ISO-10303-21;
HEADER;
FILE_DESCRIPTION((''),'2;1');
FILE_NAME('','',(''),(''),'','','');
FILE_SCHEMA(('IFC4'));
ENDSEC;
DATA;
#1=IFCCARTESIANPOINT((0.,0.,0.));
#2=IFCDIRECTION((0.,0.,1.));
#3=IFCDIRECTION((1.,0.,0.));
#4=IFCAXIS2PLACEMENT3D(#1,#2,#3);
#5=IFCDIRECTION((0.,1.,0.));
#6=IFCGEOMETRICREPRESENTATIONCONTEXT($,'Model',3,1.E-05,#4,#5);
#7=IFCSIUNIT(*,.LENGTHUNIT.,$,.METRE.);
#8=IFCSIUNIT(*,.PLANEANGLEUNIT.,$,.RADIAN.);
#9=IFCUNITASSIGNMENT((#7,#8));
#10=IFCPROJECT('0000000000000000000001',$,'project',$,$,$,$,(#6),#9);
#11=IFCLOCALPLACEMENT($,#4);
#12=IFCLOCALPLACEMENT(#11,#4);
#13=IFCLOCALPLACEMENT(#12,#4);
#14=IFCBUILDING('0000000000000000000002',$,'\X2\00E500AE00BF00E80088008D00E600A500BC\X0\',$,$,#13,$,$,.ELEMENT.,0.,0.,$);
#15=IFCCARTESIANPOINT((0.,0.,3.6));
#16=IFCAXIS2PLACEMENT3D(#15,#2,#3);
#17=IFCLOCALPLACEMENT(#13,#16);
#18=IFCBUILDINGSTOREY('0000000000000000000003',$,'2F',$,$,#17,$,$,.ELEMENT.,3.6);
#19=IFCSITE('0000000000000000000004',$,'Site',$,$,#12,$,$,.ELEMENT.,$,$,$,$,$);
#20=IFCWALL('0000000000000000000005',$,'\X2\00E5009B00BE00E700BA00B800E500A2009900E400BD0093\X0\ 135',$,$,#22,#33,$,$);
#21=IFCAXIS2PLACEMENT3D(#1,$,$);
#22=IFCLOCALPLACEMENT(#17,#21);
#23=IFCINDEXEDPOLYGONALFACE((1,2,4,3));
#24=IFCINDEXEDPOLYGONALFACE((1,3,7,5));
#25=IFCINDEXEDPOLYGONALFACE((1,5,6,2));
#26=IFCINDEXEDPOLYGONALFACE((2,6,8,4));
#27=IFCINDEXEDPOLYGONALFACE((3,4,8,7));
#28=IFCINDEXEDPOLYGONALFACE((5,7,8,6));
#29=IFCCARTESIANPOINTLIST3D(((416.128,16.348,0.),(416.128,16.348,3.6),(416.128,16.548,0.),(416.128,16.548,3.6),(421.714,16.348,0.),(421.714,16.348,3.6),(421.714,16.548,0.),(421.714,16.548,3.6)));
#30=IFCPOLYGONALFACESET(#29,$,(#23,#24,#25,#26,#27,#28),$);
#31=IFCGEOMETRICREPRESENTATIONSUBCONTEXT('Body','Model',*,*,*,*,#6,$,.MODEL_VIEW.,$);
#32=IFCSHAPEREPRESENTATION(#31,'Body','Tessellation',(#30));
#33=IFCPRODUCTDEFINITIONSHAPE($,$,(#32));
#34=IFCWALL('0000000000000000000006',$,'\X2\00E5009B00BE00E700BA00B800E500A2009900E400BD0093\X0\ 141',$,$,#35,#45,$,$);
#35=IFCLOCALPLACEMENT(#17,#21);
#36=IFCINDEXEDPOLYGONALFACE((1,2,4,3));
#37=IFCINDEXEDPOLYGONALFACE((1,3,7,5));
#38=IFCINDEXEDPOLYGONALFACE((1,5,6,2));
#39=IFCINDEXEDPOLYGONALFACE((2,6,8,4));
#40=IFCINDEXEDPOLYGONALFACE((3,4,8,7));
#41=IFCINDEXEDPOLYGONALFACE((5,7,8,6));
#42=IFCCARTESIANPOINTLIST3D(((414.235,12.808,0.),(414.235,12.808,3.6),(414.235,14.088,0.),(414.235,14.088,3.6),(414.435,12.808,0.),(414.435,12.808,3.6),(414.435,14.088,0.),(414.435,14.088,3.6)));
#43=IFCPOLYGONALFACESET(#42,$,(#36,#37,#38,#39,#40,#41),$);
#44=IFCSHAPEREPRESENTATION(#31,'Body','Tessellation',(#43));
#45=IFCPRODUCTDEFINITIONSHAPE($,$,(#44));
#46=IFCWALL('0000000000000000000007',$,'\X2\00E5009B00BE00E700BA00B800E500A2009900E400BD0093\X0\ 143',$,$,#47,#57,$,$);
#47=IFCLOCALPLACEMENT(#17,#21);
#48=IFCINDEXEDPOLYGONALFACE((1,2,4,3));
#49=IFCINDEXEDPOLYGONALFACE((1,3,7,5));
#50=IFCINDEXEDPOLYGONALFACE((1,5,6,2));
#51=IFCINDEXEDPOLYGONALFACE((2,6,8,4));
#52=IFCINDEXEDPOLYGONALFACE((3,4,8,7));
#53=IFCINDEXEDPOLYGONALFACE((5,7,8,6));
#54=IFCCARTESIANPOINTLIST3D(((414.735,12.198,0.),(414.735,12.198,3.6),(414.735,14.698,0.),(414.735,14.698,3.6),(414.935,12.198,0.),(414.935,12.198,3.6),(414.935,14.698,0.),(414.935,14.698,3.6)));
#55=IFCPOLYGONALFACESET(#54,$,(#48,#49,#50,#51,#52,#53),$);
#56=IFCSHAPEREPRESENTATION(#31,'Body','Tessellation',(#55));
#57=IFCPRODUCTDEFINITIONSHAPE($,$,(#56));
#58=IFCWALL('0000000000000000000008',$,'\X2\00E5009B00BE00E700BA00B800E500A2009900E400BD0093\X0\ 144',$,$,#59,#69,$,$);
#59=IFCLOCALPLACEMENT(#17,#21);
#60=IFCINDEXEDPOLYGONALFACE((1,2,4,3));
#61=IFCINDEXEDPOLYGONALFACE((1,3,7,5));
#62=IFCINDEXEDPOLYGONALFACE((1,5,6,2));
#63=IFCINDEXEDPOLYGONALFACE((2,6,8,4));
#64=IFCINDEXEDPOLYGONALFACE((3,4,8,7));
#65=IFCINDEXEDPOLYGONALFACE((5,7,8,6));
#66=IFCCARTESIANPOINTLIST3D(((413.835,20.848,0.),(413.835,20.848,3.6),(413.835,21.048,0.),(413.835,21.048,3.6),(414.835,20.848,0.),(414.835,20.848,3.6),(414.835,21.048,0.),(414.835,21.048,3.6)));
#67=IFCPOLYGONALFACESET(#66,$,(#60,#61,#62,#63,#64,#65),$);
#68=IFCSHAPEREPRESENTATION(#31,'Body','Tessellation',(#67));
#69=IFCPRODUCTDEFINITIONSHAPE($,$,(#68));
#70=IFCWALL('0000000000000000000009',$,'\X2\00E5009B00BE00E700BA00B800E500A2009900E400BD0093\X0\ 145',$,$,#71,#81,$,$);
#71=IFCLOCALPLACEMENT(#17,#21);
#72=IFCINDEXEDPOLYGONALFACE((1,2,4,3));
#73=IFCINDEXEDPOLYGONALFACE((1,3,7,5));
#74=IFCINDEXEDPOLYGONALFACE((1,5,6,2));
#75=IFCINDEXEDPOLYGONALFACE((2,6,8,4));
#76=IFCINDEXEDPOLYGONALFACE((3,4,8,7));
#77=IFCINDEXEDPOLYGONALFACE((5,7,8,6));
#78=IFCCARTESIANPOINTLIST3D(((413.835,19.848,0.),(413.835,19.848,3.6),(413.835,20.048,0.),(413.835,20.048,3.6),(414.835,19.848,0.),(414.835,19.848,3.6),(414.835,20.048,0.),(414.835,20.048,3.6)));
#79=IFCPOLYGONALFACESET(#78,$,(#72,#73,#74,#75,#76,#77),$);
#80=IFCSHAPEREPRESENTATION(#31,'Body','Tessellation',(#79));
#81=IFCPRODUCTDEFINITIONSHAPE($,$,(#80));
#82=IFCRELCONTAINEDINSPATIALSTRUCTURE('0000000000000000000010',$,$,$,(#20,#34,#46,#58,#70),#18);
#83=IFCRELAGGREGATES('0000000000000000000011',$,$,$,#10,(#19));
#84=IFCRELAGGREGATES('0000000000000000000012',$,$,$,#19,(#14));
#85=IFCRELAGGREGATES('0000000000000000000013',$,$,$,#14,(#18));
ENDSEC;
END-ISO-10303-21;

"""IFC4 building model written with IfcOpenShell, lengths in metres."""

from ifc_helpers import new_model, si_unit, direction, frame, frame_2d, origin_with_axes, place, context, subcontext, project, spatial, rectangle, extrude, element, save


model = new_model("IFC4")

# Units and contexts
model_context = context("Model", 3, precision=1e-05, world=origin_with_axes(), true_north=direction((0.0, 1.0, 0.0)))
body_context = subcontext(model_context, "Body", "Model", "MODEL_VIEW")
ifc_project = project(units=[si_unit("LENGTHUNIT", "METRE"), si_unit("PLANEANGLEUNIT", "RADIAN")], contexts=[model_context])

# Site, building, storey
placement = place(None, origin_with_axes())
site_placement = place(placement, origin_with_axes())
site = spatial("IfcSite", under=ifc_project, at=site_placement, Name="Site", CompositionType="ELEMENT")
building_placement = place(site_placement, origin_with_axes())
building = spatial("IfcBuilding", under=site, at=building_placement, Name="å®¿è\u0088\u008dæ¥¼", CompositionType="ELEMENT", ElevationOfRefHeight=0.0, ElevationOfTerrain=0.0)
storey_placement = place(building_placement, frame((0.0, 0.0, 3.6), z_axis=(0.0, 0.0, 1.0), x_axis=(1.0, 0.0, 0.0)))
storey = spatial("IfcBuildingStorey", under=building, at=storey_placement, Name="2F", CompositionType="ELEMENT", Elevation=3.6)

# Walls
wall_1_placement = place(storey_placement, frame((418.921, 16.448, 0.0), z_axis=(0.0, 0.0, 1.0), x_axis=(-1.0, 0.0, 0.0)))
element("IfcWall", 1, at=wall_1_placement, inside=storey, Name="å\u009b¾çº¸å¢\u0099ä½\u0093 135", context=body_context, shape_type="SweptSolid", body=[
    extrude(rectangle(XDim=5.586, YDim=0.2, at=frame_2d((0.0, 0.0), x_axis=(1.0, 0.0, 0.0))), frame((0.0, 0.0, 0.0), z_axis=(0.0, 0.0, 1.0)), (0.0, 0.0, 1.0), 3.6),
])
wall_2_placement = place(storey_placement, frame((414.335, 13.448, 0.0), z_axis=(0.0, 0.0, 1.0), x_axis=(0.0, -1.0, 0.0)))
element("IfcWall", 2, at=wall_2_placement, inside=storey, Name="å\u009b¾çº¸å¢\u0099ä½\u0093 141", context=body_context, shape_type="SweptSolid", body=[
    extrude(rectangle(XDim=1.28, YDim=0.2, at=frame_2d((0.0, 0.0), x_axis=(1.0, 0.0, 0.0))), frame((0.0, 0.0, 0.0), z_axis=(0.0, 0.0, 1.0)), (0.0, 0.0, 1.0), 3.6),
])
wall_3_placement = place(storey_placement, frame((414.835, 13.448, 0.0), z_axis=(0.0, 0.0, 1.0), x_axis=(0.0, 1.0, 0.0)))
element("IfcWall", 3, at=wall_3_placement, inside=storey, Name="å\u009b¾çº¸å¢\u0099ä½\u0093 143", context=body_context, shape_type="SweptSolid", body=[
    extrude(rectangle(XDim=2.5, YDim=0.2, at=frame_2d((0.0, 0.0), x_axis=(1.0, 0.0, 0.0))), frame((0.0, 0.0, 0.0), z_axis=(0.0, 0.0, 1.0)), (0.0, 0.0, 1.0), 3.6),
])
for number, where, z_axis, x_axis, name in (
    (4, (414.335, 20.948, 0.0), (0.0, 0.0, 1.0), (-1.0, 0.0, 0.0), "å\u009b¾çº¸å¢\u0099ä½\u0093 144"),
    (5, (414.335, 19.948, 0.0), (0.0, 0.0, 1.0), (-1.0, 0.0, 0.0), "å\u009b¾çº¸å¢\u0099ä½\u0093 145"),
):
    element("IfcWall", number, at=place(storey_placement, frame(where, z_axis=z_axis, x_axis=x_axis)), inside=storey, Name=name, context=body_context, shape_type="SweptSolid", body=[
        extrude(rectangle(XDim=1.0, YDim=0.2, at=frame_2d((0.0, 0.0), x_axis=(1.0, 0.0, 0.0))), frame((0.0, 0.0, 0.0), z_axis=(0.0, 0.0, 1.0)), (0.0, 0.0, 1.0), 3.6),
    ])

save(model, "model.ifc")
